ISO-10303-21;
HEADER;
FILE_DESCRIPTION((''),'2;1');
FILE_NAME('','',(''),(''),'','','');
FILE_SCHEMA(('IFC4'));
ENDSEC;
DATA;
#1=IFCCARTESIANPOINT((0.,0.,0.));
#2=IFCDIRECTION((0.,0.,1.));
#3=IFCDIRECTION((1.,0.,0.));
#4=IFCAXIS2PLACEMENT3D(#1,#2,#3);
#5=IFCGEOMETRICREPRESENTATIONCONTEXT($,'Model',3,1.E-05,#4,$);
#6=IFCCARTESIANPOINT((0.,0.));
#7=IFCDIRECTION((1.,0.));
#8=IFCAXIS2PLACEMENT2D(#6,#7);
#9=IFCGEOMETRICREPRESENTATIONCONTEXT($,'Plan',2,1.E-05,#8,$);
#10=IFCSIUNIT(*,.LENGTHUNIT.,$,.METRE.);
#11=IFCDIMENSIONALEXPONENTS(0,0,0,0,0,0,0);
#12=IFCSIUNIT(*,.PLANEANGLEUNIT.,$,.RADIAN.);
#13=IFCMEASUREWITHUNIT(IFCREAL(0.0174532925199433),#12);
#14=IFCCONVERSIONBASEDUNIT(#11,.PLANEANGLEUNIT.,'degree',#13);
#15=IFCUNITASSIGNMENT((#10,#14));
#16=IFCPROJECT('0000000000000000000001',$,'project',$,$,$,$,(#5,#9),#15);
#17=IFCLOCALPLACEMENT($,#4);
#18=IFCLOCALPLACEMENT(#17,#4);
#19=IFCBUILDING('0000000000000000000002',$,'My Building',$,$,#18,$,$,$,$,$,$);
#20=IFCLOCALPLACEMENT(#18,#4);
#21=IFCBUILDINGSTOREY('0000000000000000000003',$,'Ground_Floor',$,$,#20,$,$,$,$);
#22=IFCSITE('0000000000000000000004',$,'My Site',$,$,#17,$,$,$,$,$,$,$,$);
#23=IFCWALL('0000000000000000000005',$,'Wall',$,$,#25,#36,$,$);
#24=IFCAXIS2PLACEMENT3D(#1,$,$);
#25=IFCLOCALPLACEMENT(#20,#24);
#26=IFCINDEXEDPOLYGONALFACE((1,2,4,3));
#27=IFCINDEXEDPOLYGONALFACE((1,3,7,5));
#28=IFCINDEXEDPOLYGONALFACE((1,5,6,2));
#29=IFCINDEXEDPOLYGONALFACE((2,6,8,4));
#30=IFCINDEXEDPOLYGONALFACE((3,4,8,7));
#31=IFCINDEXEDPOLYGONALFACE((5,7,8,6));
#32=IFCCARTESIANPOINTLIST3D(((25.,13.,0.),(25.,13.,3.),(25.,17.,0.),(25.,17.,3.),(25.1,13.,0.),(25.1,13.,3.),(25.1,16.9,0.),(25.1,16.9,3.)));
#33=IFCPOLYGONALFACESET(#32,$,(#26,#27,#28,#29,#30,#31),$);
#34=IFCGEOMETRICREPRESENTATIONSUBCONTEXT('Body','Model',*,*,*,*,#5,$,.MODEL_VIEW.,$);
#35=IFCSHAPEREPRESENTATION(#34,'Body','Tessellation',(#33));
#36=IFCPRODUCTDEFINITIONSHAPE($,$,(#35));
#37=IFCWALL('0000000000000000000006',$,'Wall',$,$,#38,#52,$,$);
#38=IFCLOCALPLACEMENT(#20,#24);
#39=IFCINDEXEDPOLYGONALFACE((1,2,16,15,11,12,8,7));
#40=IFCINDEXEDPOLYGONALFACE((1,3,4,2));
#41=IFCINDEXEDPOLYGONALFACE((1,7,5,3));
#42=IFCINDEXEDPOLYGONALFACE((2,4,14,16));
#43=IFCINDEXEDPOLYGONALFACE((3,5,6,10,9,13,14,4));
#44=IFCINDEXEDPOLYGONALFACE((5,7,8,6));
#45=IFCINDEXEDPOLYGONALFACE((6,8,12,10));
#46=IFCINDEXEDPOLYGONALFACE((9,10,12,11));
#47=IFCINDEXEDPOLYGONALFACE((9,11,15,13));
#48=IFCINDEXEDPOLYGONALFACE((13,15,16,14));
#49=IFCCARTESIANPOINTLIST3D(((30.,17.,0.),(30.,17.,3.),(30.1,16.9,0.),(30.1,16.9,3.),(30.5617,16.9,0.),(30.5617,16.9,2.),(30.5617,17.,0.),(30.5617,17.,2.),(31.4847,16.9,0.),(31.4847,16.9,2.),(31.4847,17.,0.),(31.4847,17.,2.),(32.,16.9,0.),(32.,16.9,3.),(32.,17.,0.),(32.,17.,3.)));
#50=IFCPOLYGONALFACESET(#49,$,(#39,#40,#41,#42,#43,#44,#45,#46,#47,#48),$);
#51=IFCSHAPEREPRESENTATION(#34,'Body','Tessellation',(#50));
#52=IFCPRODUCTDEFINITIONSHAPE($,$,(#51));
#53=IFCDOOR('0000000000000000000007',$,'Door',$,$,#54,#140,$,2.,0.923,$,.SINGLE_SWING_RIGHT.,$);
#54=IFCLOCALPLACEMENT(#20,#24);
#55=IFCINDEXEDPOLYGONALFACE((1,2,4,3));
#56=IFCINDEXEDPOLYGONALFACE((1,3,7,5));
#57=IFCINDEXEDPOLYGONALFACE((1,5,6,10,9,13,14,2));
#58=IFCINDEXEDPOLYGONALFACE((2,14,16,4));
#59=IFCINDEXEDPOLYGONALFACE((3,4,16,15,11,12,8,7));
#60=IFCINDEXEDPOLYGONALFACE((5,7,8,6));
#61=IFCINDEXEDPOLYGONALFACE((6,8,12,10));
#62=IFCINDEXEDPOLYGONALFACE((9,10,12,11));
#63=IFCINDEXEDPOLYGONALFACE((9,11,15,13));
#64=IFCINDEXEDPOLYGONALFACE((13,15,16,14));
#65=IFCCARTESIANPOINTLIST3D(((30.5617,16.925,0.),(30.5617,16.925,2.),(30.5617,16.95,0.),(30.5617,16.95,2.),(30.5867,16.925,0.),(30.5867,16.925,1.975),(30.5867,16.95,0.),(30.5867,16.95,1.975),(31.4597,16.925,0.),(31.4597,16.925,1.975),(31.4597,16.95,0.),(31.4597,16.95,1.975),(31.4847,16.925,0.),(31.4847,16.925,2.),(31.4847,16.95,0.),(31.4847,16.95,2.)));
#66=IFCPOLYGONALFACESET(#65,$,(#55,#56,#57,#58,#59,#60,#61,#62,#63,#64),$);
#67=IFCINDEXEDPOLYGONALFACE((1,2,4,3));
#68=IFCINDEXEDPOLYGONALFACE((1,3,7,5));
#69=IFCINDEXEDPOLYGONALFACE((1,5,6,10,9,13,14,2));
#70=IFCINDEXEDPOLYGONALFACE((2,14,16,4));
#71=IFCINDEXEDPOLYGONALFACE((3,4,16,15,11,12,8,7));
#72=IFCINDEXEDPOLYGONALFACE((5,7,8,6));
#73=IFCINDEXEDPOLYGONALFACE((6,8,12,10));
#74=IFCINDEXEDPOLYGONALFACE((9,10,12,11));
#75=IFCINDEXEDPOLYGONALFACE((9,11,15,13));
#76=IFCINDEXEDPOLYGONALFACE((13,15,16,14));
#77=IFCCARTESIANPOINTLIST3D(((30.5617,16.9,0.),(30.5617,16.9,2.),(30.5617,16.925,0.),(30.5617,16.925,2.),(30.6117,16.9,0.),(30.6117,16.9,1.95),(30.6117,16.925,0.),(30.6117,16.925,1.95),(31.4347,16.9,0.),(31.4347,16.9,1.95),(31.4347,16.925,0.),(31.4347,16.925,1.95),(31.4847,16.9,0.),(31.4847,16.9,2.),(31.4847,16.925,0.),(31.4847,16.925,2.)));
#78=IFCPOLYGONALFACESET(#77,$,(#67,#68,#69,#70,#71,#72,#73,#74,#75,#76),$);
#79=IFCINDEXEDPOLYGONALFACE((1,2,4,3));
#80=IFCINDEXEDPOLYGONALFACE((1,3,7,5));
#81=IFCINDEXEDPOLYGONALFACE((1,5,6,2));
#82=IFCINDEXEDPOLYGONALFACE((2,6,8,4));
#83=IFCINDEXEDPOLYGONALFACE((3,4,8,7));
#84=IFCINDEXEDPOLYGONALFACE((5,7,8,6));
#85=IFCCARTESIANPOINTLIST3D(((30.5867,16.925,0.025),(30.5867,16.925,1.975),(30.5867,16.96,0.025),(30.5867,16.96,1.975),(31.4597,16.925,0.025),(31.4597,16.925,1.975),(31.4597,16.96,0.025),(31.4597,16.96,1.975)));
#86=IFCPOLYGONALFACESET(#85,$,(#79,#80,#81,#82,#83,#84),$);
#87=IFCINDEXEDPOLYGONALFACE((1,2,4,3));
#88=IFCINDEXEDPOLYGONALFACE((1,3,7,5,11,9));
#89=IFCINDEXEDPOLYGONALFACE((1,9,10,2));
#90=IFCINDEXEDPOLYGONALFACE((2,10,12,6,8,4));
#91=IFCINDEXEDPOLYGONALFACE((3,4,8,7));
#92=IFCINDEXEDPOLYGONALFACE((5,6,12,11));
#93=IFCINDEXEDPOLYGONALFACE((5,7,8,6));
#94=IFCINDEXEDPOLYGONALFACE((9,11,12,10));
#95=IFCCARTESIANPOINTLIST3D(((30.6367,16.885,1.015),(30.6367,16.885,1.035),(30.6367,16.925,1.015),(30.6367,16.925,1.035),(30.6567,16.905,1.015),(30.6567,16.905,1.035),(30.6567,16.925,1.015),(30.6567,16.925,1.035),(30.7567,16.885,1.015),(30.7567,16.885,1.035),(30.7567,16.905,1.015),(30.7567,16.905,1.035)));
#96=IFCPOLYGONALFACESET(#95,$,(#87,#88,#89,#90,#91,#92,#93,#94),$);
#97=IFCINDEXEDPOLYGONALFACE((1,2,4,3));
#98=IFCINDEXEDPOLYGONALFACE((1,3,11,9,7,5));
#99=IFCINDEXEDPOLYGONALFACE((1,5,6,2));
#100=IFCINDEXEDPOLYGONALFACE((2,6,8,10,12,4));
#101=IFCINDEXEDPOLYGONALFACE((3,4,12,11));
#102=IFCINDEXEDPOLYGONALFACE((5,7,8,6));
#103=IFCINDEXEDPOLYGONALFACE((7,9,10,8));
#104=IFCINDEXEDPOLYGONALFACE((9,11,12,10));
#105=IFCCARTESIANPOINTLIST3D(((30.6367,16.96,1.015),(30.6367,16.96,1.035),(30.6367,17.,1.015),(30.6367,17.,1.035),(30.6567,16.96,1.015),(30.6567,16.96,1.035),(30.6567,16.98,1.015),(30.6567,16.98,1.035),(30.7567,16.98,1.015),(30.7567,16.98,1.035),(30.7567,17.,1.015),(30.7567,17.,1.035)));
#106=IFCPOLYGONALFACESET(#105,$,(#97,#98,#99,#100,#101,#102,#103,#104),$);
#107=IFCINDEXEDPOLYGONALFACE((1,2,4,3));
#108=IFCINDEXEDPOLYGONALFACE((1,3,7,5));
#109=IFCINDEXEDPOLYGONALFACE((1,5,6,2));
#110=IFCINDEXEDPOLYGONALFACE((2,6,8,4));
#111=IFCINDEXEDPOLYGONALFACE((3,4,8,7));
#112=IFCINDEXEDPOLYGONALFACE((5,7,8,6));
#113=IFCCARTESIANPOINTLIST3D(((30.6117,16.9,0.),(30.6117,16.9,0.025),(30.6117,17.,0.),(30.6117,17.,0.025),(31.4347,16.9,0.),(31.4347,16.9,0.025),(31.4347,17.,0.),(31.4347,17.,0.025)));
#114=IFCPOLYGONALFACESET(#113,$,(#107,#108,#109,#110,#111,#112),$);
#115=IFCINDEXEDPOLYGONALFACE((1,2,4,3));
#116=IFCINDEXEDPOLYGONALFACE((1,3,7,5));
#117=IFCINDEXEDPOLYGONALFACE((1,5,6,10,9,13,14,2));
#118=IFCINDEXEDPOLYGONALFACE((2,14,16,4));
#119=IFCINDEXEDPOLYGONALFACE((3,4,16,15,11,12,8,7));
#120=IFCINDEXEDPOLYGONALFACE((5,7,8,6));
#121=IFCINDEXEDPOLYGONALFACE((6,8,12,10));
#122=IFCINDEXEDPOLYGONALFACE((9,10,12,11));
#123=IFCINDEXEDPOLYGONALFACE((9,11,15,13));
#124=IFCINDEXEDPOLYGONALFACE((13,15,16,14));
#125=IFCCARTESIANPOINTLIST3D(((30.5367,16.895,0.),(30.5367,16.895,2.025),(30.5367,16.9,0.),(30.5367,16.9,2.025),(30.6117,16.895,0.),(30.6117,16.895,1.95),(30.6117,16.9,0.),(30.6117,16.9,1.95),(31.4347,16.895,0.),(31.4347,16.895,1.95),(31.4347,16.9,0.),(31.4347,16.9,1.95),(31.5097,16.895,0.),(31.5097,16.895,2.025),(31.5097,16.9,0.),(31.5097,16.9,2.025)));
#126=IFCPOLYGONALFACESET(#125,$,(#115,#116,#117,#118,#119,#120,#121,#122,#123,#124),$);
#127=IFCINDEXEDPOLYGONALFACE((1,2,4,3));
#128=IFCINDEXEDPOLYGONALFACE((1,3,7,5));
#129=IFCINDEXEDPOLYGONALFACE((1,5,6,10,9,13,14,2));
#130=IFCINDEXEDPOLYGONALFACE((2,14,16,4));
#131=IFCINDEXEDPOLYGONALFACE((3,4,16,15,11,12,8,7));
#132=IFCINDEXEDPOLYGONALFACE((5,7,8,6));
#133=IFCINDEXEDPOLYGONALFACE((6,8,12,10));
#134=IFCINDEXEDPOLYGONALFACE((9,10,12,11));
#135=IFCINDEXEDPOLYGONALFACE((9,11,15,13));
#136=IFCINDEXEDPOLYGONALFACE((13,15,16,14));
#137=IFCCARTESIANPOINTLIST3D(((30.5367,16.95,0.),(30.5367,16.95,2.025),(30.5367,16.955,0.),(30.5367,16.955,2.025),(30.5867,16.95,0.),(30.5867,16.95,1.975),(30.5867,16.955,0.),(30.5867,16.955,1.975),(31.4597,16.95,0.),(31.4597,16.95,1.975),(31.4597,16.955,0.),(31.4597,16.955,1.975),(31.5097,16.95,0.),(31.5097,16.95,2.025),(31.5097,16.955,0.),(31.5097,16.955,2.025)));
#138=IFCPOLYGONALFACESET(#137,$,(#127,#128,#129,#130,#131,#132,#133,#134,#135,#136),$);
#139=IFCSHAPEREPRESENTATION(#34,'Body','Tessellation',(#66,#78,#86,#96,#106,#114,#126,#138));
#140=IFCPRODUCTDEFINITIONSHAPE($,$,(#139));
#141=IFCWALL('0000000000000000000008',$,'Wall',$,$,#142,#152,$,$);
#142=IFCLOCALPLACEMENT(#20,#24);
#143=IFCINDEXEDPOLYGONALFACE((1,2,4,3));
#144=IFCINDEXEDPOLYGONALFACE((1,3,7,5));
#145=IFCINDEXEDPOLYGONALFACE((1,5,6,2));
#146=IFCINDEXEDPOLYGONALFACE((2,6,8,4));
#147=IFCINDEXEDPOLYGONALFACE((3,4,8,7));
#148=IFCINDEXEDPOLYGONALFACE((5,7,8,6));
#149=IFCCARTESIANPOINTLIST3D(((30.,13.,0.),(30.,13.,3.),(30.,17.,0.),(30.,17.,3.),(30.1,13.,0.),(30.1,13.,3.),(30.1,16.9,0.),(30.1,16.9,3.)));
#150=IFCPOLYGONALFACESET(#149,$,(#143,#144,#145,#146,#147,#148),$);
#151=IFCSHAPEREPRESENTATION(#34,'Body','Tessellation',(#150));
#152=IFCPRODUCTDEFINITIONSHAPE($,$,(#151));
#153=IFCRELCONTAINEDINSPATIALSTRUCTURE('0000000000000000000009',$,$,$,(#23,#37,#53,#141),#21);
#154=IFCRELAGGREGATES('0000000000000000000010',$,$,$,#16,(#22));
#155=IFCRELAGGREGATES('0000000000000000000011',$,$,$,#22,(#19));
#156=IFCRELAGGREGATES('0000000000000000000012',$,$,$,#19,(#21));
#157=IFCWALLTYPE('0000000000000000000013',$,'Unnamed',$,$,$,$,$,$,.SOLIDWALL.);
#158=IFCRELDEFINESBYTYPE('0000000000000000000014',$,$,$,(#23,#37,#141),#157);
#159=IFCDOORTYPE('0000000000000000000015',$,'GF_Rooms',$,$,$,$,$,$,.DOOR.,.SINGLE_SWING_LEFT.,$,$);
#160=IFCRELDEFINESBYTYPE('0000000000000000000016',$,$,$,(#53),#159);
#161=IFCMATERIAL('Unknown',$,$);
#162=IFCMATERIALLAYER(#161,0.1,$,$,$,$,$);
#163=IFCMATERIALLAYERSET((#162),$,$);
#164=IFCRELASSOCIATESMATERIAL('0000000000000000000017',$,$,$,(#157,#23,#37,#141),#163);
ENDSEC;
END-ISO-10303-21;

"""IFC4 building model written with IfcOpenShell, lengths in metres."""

from ifc_helpers import new_model, entity, si_unit, converted_unit, frame, origin_with_axes, origin_2d_with_axis, place, context, subcontext, project, spatial, line, indexed_curve, outline, extrude, shape, source, transform, mapped, material, layer, layer_set, layer_usage, type_object, type_shapes, element, fill, save


model = new_model("IFC4")

# Units and contexts
model_context = context("Model", 3, precision=1e-05, world=origin_with_axes())
plan_context = context("Plan", 2, precision=1e-05, world=origin_2d_with_axis())
body_context_1 = subcontext(model_context, "Body", "Model", "MODEL_VIEW")
body_context_2 = subcontext(plan_context, "Body", "Plan", "PLAN_VIEW")
ifc_project = project(units=[si_unit("LENGTHUNIT", "METRE"), converted_unit("PLANEANGLEUNIT", "degree", entity("IfcReal", 0.0174532925199433), si_unit("PLANEANGLEUNIT", "RADIAN"), dimensions=[0, 0, 0, 0, 0, 0, 0])], contexts=[model_context, plan_context])

# Site, building, storey
site_placement = place(None, origin_with_axes())
site = spatial("IfcSite", under=ifc_project, at=site_placement, Name="My Site")
building_placement = place(site_placement, origin_with_axes())
building = spatial("IfcBuilding", under=site, at=building_placement, Name="My Building")
storey_placement = place(building_placement, origin_with_axes())
storey = spatial("IfcBuildingStorey", under=building, at=storey_placement, Name="Ground_Floor")

# Shared definitions
ifc_material = material(Name="Unknown")
ifc_layer = layer(ifc_material, 0.1)
ifc_layer_set = layer_set([ifc_layer])
wall_type = type_object("IfcWallType", Name="Unnamed", PredefinedType="SOLIDWALL", material=ifc_layer_set)

# Wall
ifc_layer_usage_1 = layer_usage(ifc_layer_set, "AXIS2", "POSITIVE", 0.0)
wall_1_placement = place(storey_placement, frame((25.0, 17.0, 0.0), z_axis=(0.0, 0.0, 1.0), x_axis=(0.0, -1.0, 0.0)))
element("IfcWall", 1, at=wall_1_placement, inside=storey, type_object=wall_type, material=ifc_layer_usage_1, Name="Wall", context=body_context_1, shape_type="SweptSolid", body=[
    extrude(outline(indexed_curve([(0.0, 0.0), (0.1, 0.1), (4.0, 0.1), (4.0, 0.0)], segments=[line(1, 2, 3, 4, 1)])), origin_with_axes(), (0.0, 0.0, 1.0), 3.0),
])

# Wall, opening, door
ifc_layer_usage_2 = layer_usage(ifc_layer_set, "AXIS2", "POSITIVE", 0.0)
wall_2_placement = place(storey_placement, frame((32.0, 17.0, 0.0), z_axis=(0.0, 0.0, 1.0), x_axis=(-1.0, 0.0, 0.0)))
wall_2 = element("IfcWall", 2, at=wall_2_placement, inside=storey, type_object=wall_type, material=ifc_layer_usage_2, Name="Wall", context=body_context_1, shape_type="SweptSolid", body=[
    extrude(outline(indexed_curve([(0.0, 0.0), (0.0, 0.1), (1.9, 0.1), (2.0, 0.0)], segments=[line(1, 2, 3, 4, 1)])), origin_with_axes(), (0.0, 0.0, 1.0), 3.0),
])
shared_shape_1 = source(origin_with_axes(), body_context_1, "Body", "SweptSolid", [
    extrude(outline(indexed_curve([(0.0, 0.0), (0.923, 0.0), (0.923, 2.0), (0.0, 2.0)], segments=[line(1, 2, 3, 4, 1)])), frame((0.0, -0.6, 0.0), z_axis=(0.0, -1.0, 0.0), x_axis=(1.0, 0.0, 0.0)), (0.0, 0.0, -1.0), 1.2),
])
opening_1_placement = place(wall_2_placement, frame((1.4383, 0.1, 0.0), z_axis=(0.0, 0.0, 1.0), x_axis=(-1.0, 0.0, 0.0)))
opening_1 = element("IfcOpeningElement", 3, at=opening_1_placement, cuts=wall_2, PredefinedType="OPENING", context=body_context_1, shape_type="MappedRepresentation", body=[
    mapped(shared_shape_1, transform((0.0, 0.0, 0.0), x_axis=(1.0, 0.0, 0.0), y_axis=(0.0, 1.0, 0.0), z_axis=(0.0, 0.0, 1.0), scale=1.0)),
])
door_type_1 = type_object("IfcDoorType", Name="GF_Rooms", OperationType="SINGLE_SWING_LEFT", PredefinedType="DOOR")
shared_shape_2 = source(origin_with_axes(), body_context_1, "Body", "SweptSolid", [
    extrude(outline(indexed_curve([(0.0, 0.0), (0.0, 2.0), (0.923, 2.0), (0.923, 0.0), (0.898, 0.0), (0.898, 1.975), (0.025, 1.975), (0.025, 0.0)], segments=[line(1, 2, 3, 4, 5, 6, 7, 8, 1)])), frame((0.0, 0.025, 0.0), z_axis=(0.0, -1.0, 0.0), x_axis=(1.0, 0.0, 0.0)), (0.0, 0.0, -1.0), 0.025),
    extrude(outline(indexed_curve([(0.0, 0.0), (0.0, 2.0), (0.923, 2.0), (0.923, 0.0), (0.873, 0.0), (0.873, 1.95), (0.05, 1.95), (0.05, 0.0)], segments=[line(1, 2, 3, 4, 5, 6, 7, 8, 1)])), frame((0.0, 0.0, 0.0), z_axis=(0.0, -1.0, 0.0), x_axis=(1.0, 0.0, 0.0)), (0.0, 0.0, -1.0), 0.025),
    extrude(outline(indexed_curve([(0.0, 0.0), (0.873, 0.0), (0.873, 0.035), (0.0, 0.035)], segments=[line(1, 2, 3, 4, 1)])), frame((0.025, 0.025, 0.025), z_axis=(0.0, 0.0, 1.0), x_axis=(1.0, 0.0, 0.0)), (0.0, 0.0, 1.0), 1.95),
    extrude(outline(indexed_curve([(0.0, 0.0), (0.0, -0.04), (0.12, -0.04), (0.12, -0.02), (0.02, -0.02), (0.02, 0.0)], segments=[line(1, 2, 3, 4, 5, 6, 1)])), frame((0.075, 0.025, 1.015), z_axis=(0.0, 0.0, 1.0), x_axis=(1.0, 0.0, 0.0)), (0.0, 0.0, 1.0), 0.02),
    extrude(outline(indexed_curve([(0.0, 0.0), (0.0, 0.04), (0.12, 0.04), (0.12, 0.02), (0.02, 0.02), (0.02, 0.0)], segments=[line(1, 2, 3, 4, 5, 6, 1)])), frame((0.075, 0.06, 1.015), z_axis=(0.0, 0.0, 1.0), x_axis=(1.0, 0.0, 0.0)), (0.0, 0.0, 1.0), 0.02),
    extrude(outline(indexed_curve([(0.0, 0.0), (0.823, 0.0), (0.823, 0.1), (0.0, 0.1)], segments=[line(1, 2, 3, 4, 1)])), frame((0.05, 0.0, 0.0), z_axis=(0.0, 0.0, 1.0), x_axis=(1.0, 0.0, 0.0)), (0.0, 0.0, 1.0), 0.025),
    extrude(outline(indexed_curve([(0.0, 0.0), (0.0, 2.025), (0.973, 2.025), (0.973, 0.0), (0.898, 0.0), (0.898, 1.95), (0.075, 1.95), (0.075, 0.0)], segments=[line(1, 2, 3, 4, 5, 6, 7, 8, 1)])), frame((-0.025, -0.005, 0.0), z_axis=(0.0, -1.0, 0.0), x_axis=(1.0, 0.0, 0.0)), (0.0, 0.0, -1.0), 0.005),
    extrude(outline(indexed_curve([(0.0, 0.0), (0.0, 2.025), (0.973, 2.025), (0.973, 0.0), (0.923, 0.0), (0.923, 1.975), (0.05, 1.975), (0.05, 0.0)], segments=[line(1, 2, 3, 4, 5, 6, 7, 8, 1)])), frame((-0.025, 0.05, 0.0), z_axis=(0.0, -1.0, 0.0), x_axis=(1.0, 0.0, 0.0)), (0.0, 0.0, -1.0), 0.005),
])
shared_shape_3 = source(origin_with_axes(), body_context_2, "Body", "Curve2D", [
    entity("IfcIndexedPolyCurve", entity("IfcCartesianPointList2D", [[0.0, 0.0], [0.0, 0.05], [0.025, 0.05], [0.025, 0.025], [0.05, 0.025], [0.05, 0.0]]), [entity("IfcLineIndex", [1, 2, 3, 4, 5, 6, 1])]),
    entity("IfcIndexedPolyCurve", entity("IfcCartesianPointList2D", [[0.923, 0.0], [0.923, 0.05], [0.898, 0.05], [0.898, 0.025], [0.873, 0.025], [0.873, 0.0]]), [entity("IfcLineIndex", [1, 2, 3, 4, 5, 6, 1])]),
    entity("IfcTrimmedCurve", entity("IfcEllipse", entity("IfcAxis2Placement2D", entity("IfcCartesianPoint", [0.863, 0.05]), entity("IfcDirection", [1.0, 0.0])), 0.838, 0.873), [entity("IfcCartesianPoint", [0.863, 0.923])], [entity("IfcCartesianPoint", [0.025, 0.05])], True, "CARTESIAN"),
    entity("IfcIndexedPolyCurve", entity("IfcCartesianPointList2D", [[0.898, 0.05], [0.863, 0.05], [0.863, 0.923], [0.898, 0.923]]), [entity("IfcLineIndex", [1, 2, 3, 4, 1])]),
])
type_shapes(door_type_1, [shared_shape_2, shared_shape_3])
door_1_placement = place(opening_1_placement, frame((0.0, 0.0, 0.0), z_axis=(0.0, 0.0, 1.0), x_axis=(1.0, 0.0, 0.0)))
door_1 = element("IfcDoor", 4, at=door_1_placement, inside=storey, type_object=door_type_1, Name="Door", OperationType="SINGLE_SWING_RIGHT", OverallHeight=2.0, OverallWidth=0.923, shapes=[
    shape(body_context_1, "Body", "MappedRepresentation", [mapped(shared_shape_2, transform((0.0, 0.0, 0.0), x_axis=(1.0, 0.0, 0.0), y_axis=(0.0, 1.0, 0.0), z_axis=(0.0, 0.0, 1.0), scale=1.0))]),
    shape(body_context_2, "Body", "MappedRepresentation", [mapped(shared_shape_3, transform((0.0, 0.0, 0.0), x_axis=(1.0, 0.0, 0.0), y_axis=(0.0, 1.0, 0.0), z_axis=(0.0, 0.0, 1.0), scale=1.0))]),
])
fill(opening_1, door_1)

# Wall
ifc_layer_usage_3 = layer_usage(ifc_layer_set, "AXIS2", "POSITIVE", 0.0)
wall_3_placement = place(storey_placement, frame((30.0, 17.0, 0.0), z_axis=(0.0, 0.0, 1.0), x_axis=(0.0, -1.0, 0.0)))
element("IfcWall", 5, at=wall_3_placement, inside=storey, type_object=wall_type, material=ifc_layer_usage_3, Name="Wall", context=body_context_1, shape_type="SweptSolid", body=[
    extrude(outline(indexed_curve([(0.0, 0.0), (0.1, 0.1), (4.0, 0.1), (4.0, 0.0)], segments=[line(1, 2, 3, 4, 1)])), origin_with_axes(), (0.0, 0.0, 1.0), 3.0),
])

save(model, "model.ifc")
